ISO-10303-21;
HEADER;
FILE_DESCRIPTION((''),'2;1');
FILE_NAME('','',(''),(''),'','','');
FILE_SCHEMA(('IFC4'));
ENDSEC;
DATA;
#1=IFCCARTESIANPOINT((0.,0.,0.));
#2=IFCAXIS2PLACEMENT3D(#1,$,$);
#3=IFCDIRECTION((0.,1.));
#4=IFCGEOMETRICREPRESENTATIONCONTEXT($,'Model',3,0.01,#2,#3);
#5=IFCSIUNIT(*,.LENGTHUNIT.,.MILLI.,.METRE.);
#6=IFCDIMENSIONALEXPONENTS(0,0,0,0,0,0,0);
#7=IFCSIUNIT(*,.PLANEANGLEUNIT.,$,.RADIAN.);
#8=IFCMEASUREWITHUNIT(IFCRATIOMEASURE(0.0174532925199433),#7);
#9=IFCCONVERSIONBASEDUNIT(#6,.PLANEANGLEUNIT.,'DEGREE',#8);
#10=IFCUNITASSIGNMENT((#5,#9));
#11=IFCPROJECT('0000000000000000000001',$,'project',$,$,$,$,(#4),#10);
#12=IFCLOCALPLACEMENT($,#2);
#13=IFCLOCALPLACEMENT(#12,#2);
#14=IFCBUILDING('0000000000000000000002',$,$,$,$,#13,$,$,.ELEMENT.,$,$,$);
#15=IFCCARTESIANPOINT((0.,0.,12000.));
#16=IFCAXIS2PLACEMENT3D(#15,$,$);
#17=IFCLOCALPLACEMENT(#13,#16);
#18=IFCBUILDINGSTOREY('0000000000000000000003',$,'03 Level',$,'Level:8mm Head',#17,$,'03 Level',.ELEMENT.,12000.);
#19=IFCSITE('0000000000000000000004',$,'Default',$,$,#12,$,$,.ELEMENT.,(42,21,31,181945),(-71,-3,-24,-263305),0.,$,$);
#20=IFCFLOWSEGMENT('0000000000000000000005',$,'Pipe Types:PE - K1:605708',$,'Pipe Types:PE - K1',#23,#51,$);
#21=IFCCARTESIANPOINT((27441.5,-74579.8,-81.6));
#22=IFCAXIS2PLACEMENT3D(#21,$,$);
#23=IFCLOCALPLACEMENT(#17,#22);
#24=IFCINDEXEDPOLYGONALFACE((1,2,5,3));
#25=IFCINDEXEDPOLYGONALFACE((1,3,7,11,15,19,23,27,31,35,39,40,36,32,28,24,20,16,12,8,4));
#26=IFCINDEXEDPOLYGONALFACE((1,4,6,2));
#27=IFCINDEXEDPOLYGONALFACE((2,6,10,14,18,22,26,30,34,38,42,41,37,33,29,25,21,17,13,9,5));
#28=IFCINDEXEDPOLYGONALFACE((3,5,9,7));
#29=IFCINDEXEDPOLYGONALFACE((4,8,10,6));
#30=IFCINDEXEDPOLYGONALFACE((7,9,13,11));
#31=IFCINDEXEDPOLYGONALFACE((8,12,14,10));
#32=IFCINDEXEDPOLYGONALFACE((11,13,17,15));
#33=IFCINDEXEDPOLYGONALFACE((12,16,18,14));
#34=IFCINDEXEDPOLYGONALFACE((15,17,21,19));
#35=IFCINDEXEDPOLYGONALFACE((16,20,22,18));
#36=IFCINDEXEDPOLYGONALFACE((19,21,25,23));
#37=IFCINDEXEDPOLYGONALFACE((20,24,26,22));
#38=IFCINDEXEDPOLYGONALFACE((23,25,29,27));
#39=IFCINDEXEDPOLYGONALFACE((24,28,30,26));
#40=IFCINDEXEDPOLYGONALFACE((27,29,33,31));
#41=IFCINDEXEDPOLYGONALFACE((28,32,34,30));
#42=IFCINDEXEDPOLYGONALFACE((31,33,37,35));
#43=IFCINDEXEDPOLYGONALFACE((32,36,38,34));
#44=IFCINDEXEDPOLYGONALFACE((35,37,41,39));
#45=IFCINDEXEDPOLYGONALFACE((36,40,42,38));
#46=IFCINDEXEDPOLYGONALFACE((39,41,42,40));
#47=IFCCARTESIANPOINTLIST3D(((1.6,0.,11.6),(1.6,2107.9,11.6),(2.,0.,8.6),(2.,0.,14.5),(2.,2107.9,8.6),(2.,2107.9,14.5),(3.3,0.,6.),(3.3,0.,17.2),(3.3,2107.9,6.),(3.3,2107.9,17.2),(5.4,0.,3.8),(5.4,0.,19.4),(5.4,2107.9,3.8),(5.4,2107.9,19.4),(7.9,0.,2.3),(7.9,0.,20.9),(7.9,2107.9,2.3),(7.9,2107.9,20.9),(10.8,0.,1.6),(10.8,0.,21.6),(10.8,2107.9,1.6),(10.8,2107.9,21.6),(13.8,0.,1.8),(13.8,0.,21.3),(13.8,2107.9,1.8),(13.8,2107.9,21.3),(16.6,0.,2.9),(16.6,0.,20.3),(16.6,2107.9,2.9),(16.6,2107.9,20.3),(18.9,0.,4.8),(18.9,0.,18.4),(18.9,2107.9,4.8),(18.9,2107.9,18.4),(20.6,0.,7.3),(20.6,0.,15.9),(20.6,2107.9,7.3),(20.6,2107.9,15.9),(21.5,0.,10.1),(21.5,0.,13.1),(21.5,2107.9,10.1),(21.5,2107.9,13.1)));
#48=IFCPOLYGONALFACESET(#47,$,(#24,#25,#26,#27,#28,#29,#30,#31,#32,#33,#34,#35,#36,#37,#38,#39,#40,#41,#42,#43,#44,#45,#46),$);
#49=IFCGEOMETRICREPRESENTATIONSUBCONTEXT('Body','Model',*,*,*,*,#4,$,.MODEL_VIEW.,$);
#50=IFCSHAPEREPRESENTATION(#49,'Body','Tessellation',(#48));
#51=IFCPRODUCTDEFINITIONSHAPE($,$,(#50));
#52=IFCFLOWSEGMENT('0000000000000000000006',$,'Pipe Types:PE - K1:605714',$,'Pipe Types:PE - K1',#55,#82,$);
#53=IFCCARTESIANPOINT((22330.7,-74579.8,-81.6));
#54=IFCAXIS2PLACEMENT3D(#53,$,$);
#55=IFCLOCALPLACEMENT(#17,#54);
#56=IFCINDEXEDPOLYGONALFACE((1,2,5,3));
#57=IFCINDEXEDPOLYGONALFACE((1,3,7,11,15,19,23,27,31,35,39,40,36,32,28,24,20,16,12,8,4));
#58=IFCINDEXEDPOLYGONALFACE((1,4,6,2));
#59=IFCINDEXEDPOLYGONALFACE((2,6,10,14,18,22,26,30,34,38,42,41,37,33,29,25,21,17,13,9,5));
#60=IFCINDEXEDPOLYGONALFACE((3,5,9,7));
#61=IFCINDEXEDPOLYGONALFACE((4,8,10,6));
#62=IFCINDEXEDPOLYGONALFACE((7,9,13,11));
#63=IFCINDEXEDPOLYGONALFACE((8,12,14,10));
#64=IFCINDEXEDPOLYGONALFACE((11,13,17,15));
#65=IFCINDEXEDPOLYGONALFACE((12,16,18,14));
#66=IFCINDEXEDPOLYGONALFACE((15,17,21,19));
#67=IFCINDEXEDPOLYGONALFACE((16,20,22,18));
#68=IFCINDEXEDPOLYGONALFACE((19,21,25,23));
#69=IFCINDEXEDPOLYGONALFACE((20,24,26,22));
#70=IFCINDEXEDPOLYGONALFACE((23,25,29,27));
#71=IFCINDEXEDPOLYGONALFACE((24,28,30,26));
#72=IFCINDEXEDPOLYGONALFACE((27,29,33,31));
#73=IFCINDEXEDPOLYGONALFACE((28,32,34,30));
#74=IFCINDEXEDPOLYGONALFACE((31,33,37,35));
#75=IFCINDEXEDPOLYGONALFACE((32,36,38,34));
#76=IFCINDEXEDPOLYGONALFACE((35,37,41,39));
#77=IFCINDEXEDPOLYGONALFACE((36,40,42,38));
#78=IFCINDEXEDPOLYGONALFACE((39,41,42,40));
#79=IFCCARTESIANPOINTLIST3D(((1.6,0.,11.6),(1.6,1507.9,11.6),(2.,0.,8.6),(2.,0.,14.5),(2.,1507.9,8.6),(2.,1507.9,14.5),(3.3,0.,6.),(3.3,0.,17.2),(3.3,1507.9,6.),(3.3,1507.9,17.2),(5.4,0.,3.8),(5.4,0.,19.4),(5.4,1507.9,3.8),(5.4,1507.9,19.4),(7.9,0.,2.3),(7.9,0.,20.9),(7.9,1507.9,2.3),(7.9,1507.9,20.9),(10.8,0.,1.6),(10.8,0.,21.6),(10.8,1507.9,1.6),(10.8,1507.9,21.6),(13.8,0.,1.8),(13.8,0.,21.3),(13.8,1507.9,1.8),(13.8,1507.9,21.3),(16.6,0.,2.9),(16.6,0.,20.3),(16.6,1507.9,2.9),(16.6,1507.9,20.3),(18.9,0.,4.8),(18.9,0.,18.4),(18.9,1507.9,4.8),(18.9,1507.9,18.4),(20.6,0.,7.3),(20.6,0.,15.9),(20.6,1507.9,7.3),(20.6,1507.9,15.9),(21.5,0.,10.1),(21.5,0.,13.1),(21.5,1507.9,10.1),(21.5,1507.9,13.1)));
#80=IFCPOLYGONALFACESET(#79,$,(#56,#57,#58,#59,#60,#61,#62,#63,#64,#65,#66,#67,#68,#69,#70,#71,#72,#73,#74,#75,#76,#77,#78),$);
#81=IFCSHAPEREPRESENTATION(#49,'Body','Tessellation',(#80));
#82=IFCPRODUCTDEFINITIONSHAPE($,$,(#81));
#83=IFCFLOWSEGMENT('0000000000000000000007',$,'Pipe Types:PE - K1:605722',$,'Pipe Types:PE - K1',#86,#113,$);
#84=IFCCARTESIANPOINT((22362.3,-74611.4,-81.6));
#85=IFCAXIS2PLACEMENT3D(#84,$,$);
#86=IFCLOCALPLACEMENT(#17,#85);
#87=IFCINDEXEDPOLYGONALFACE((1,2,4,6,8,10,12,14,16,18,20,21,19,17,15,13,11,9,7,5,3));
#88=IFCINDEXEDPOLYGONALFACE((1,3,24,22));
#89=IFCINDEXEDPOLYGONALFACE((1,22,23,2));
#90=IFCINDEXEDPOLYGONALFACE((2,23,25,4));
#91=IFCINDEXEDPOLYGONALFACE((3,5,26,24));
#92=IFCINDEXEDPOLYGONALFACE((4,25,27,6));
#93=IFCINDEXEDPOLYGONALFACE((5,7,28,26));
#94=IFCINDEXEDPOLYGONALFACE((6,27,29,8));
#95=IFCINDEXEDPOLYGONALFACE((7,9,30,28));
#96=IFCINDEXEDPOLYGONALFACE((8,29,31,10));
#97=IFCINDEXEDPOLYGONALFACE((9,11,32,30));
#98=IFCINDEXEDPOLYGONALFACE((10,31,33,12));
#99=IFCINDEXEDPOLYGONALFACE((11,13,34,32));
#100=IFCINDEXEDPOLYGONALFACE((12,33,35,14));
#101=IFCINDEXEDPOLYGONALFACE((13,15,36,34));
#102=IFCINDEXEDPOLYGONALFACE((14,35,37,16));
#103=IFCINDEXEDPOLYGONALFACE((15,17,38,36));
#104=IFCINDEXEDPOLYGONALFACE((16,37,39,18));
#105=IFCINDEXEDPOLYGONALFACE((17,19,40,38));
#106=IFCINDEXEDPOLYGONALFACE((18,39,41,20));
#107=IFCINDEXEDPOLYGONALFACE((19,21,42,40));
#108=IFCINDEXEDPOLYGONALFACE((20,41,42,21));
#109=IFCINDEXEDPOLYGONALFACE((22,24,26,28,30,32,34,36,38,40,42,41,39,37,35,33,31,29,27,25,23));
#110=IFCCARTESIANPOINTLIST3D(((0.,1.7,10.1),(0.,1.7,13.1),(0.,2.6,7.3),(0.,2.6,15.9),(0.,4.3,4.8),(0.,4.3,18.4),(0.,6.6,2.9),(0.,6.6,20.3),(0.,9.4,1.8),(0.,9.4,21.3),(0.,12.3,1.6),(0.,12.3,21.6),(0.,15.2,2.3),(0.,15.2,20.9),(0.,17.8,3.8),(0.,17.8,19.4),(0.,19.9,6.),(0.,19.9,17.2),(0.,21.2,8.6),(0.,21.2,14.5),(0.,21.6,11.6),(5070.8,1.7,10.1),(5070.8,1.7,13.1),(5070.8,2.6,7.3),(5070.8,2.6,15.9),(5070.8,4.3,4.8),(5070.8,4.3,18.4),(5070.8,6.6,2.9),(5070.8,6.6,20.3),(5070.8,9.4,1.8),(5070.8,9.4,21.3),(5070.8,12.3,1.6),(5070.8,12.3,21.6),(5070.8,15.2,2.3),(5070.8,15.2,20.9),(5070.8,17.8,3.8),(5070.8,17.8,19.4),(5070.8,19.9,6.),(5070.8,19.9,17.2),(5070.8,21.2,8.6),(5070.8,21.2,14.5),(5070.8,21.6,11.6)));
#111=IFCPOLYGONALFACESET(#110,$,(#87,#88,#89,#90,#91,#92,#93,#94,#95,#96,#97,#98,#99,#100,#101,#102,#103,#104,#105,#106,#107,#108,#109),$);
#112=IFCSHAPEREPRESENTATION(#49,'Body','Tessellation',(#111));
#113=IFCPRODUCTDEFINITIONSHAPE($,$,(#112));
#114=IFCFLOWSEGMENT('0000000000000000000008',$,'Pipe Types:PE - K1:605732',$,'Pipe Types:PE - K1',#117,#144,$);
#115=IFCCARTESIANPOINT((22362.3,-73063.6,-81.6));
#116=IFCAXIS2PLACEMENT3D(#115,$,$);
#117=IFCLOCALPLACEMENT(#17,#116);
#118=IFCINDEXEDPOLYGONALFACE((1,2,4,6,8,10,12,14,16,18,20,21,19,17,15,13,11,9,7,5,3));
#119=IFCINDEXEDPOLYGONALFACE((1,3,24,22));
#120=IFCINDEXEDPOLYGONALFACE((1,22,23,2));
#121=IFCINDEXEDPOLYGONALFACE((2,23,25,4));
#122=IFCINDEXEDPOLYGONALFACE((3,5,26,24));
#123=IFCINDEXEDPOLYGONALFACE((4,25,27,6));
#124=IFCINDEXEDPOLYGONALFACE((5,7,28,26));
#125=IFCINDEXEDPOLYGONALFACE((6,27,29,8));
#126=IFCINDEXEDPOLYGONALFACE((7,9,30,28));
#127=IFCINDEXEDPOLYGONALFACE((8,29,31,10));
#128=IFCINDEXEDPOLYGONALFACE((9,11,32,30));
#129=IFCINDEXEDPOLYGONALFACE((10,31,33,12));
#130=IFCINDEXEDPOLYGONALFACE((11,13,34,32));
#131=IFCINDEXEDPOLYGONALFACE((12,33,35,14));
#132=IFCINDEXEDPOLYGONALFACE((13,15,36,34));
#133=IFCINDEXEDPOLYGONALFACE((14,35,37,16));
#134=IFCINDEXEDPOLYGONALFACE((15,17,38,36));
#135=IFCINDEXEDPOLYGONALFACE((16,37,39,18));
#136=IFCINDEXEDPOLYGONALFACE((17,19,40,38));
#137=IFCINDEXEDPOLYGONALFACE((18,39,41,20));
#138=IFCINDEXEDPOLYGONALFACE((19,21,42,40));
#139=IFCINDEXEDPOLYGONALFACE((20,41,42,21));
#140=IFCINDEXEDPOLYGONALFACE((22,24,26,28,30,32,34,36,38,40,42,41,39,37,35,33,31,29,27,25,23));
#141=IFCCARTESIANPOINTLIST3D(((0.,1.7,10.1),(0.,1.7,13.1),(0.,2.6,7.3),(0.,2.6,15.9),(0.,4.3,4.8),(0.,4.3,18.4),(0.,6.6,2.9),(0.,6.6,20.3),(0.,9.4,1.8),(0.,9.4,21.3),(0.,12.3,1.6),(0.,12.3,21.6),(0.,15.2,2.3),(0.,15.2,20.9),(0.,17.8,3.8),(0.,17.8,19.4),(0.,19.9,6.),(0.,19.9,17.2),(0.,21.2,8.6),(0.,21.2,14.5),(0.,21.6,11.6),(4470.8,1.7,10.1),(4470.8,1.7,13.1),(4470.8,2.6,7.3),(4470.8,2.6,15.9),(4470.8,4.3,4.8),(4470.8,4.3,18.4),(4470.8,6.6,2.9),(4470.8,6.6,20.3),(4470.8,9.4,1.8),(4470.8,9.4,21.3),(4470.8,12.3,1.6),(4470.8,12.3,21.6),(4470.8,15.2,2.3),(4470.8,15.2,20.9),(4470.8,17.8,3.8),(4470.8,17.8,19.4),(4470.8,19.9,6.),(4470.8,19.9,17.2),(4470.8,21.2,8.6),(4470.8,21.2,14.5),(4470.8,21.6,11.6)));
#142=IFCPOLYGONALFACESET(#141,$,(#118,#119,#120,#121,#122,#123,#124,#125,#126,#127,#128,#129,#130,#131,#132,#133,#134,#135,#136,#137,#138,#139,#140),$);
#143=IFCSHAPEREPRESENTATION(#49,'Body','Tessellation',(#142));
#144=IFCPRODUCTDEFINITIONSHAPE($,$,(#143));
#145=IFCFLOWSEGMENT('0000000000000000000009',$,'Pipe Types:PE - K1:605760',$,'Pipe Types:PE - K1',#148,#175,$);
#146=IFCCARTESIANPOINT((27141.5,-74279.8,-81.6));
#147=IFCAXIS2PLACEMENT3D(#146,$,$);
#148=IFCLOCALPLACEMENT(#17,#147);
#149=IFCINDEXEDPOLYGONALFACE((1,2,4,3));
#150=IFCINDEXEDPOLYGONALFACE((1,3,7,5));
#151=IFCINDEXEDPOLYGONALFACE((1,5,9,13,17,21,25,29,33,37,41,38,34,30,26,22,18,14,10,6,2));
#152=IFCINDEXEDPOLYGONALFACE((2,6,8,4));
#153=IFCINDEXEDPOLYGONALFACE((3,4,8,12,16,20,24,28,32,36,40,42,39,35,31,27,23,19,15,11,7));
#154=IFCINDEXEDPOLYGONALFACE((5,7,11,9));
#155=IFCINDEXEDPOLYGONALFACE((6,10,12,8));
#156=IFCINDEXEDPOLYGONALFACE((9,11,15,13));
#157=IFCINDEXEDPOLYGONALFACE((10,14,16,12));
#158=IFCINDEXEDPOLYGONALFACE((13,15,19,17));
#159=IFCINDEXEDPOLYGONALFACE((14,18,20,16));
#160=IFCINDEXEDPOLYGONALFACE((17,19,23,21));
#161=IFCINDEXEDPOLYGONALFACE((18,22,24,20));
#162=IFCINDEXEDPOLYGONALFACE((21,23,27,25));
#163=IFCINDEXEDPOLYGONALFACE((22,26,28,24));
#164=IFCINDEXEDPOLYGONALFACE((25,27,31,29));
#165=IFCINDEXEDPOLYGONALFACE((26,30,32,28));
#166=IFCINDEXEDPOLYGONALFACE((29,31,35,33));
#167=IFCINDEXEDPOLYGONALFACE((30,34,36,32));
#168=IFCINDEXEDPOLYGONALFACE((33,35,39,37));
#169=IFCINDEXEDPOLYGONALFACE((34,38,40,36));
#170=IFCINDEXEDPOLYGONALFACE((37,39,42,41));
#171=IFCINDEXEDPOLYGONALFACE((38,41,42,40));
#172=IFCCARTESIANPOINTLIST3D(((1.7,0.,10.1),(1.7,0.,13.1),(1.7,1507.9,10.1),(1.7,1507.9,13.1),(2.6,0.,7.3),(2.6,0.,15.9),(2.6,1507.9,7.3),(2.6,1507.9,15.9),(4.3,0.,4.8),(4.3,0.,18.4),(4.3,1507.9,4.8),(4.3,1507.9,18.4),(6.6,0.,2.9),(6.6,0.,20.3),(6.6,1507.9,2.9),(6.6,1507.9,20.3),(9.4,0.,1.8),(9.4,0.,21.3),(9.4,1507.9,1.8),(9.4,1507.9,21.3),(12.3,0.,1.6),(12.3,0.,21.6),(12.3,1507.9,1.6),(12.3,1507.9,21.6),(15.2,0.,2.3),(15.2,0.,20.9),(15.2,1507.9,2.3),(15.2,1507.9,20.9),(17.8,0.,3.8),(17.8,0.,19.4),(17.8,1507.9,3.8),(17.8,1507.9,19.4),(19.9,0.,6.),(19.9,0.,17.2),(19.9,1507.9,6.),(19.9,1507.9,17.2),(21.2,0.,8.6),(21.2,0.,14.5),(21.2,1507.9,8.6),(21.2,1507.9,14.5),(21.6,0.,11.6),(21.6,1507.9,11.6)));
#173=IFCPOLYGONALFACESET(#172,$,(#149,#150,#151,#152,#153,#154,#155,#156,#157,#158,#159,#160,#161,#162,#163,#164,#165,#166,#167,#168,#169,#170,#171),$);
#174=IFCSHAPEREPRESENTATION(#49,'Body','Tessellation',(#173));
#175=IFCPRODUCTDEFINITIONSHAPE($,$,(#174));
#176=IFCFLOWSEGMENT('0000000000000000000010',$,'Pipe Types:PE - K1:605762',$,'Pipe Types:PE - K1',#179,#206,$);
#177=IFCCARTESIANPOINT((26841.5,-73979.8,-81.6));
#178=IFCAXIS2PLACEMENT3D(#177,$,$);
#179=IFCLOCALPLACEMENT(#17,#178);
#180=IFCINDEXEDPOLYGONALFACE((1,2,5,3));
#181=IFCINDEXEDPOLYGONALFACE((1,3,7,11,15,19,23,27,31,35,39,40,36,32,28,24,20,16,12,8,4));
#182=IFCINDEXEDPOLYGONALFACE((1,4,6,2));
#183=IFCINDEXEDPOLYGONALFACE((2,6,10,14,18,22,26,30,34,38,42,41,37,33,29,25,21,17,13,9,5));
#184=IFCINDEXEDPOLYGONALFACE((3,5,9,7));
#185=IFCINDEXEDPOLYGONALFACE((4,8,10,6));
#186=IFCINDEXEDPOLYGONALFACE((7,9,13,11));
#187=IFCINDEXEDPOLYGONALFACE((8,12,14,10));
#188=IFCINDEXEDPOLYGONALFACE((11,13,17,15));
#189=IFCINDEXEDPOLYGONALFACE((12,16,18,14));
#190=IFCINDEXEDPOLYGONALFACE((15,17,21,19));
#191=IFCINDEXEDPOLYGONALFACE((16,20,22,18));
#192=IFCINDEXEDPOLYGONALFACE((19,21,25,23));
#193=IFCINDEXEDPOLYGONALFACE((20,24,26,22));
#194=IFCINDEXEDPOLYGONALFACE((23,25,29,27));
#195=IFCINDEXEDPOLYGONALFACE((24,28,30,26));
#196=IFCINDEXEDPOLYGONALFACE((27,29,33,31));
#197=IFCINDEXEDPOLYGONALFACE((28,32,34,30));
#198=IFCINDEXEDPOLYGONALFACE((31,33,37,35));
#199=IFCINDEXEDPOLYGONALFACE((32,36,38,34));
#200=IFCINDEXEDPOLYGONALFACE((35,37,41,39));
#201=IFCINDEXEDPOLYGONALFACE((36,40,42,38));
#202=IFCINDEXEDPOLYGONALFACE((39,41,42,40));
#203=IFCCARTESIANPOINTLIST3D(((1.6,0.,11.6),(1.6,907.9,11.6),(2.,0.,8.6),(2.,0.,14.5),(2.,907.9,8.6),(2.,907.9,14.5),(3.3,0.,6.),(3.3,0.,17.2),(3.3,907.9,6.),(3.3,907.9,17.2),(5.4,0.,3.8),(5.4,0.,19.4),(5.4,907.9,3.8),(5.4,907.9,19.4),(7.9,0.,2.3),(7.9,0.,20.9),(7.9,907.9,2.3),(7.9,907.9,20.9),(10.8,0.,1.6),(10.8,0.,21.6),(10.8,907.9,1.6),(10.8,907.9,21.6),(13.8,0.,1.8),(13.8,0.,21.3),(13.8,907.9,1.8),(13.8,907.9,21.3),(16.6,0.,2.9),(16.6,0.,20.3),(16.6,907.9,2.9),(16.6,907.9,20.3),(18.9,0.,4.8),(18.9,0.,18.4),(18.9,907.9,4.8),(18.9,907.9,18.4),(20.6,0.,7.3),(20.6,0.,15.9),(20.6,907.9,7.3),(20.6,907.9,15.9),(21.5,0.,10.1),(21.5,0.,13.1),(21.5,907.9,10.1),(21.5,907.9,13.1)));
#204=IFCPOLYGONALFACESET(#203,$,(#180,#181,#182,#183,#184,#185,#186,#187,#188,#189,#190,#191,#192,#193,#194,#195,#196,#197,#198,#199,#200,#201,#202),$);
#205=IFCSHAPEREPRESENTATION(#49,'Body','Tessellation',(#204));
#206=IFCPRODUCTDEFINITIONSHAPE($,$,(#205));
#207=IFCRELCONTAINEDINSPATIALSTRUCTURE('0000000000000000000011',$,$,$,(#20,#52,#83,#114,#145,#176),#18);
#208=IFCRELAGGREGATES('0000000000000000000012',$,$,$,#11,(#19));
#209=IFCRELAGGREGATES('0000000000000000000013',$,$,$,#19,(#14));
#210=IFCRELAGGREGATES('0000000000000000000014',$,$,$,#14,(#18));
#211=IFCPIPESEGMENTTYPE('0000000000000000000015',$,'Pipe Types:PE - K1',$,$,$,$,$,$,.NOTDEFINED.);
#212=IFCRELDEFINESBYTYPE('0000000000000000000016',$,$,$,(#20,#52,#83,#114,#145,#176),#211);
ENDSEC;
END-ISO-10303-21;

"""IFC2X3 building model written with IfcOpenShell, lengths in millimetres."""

from ifc_helpers import new_model, entity, si_unit, converted_unit, direction, frame, frame_2d, origin, place, context, subcontext, project, spatial, circle, extrude, type_object, element, save


model = new_model("IFC2X3")

# Units and contexts
model_context = context("Model", 3, precision=0.01, world=origin(), true_north=direction((0.0, 1.0)))
body_context = subcontext(model_context, "Body", "Model", "MODEL_VIEW")
ifc_project = project(units=[si_unit("LENGTHUNIT", "METRE", prefix="MILLI"), converted_unit("PLANEANGLEUNIT", "DEGREE", entity("IfcRatioMeasure", 0.0174532925199433), si_unit("PLANEANGLEUNIT", "RADIAN"), dimensions=[0, 0, 0, 0, 0, 0, 0])], contexts=[model_context])

# Site, building, storey
site_placement = place(None, origin())
site = spatial("IfcSite", under=ifc_project, at=site_placement, Name="Default", CompositionType="ELEMENT", RefLatitude=(42, 21, 31, 181945), RefLongitude=(-71, -3, -24, -263305), RefElevation=0.0)
building_placement = place(site_placement, origin())
building = spatial("IfcBuilding", under=site, at=building_placement, CompositionType="ELEMENT")
storey_placement = place(building_placement, frame((0.0, 0.0, 12000.0)))
storey = spatial("IfcBuildingStorey", under=building, at=storey_placement, Name="03 Level", ObjectType="Level:8mm Head", LongName="03 Level", CompositionType="ELEMENT", Elevation=12000.0)

# Flow segments
pipe_segment_type = type_object("IfcPipeSegmentType", Name="Pipe Types:PE - K1", PredefinedType="NOTDEFINED")
flow_segment_1_placement = place(storey_placement, frame((27441.5, -74579.8, -81.6)))
element("IfcFlowSegment", 1, at=flow_segment_1_placement, inside=storey, type_object=pipe_segment_type, Name="Pipe Types:PE - K1:605708", ObjectType="Pipe Types:PE - K1", context=body_context, shape_type="SweptSolid", body=[
    extrude(circle(Radius=10.0, at=frame_2d((0.0, 0.0), x_axis=(1.0, 0.0))), frame((11.6, 0.0, 11.6), z_axis=(0.0, 1.0, 0.0), x_axis=(-1.0, 0.0, 0.0)), (0.0, 0.0, 1.0), 2107.9),
])
flow_segment_2_placement = place(storey_placement, frame((22330.7, -74579.8, -81.6)))
element("IfcFlowSegment", 2, at=flow_segment_2_placement, inside=storey, type_object=pipe_segment_type, Name="Pipe Types:PE - K1:605714", ObjectType="Pipe Types:PE - K1", context=body_context, shape_type="SweptSolid", body=[
    extrude(circle(Radius=10.0, at=frame_2d((0.0, 0.0), x_axis=(1.0, 0.0))), frame((11.6, 0.0, 11.6), z_axis=(0.0, 1.0, 0.0), x_axis=(-1.0, 0.0, 0.0)), (0.0, 0.0, 1.0), 1507.9),
])
flow_segment_3_placement = place(storey_placement, frame((22362.3, -74611.4, -81.6)))
element("IfcFlowSegment", 3, at=flow_segment_3_placement, inside=storey, type_object=pipe_segment_type, Name="Pipe Types:PE - K1:605722", ObjectType="Pipe Types:PE - K1", context=body_context, shape_type="SweptSolid", body=[
    extrude(circle(Radius=10.0, at=frame_2d((0.0, 0.0), x_axis=(1.0, 0.0))), frame((0.0, 11.6, 11.6), z_axis=(1.0, 0.0, 0.0), x_axis=(0.0, 1.0, 0.0)), (0.0, 0.0, 1.0), 5070.8),
])
flow_segment_4_placement = place(storey_placement, frame((22362.3, -73063.6, -81.6)))
element("IfcFlowSegment", 4, at=flow_segment_4_placement, inside=storey, type_object=pipe_segment_type, Name="Pipe Types:PE - K1:605732", ObjectType="Pipe Types:PE - K1", context=body_context, shape_type="SweptSolid", body=[
    extrude(circle(Radius=10.0, at=frame_2d((0.0, 0.0), x_axis=(1.0, 0.0))), frame((0.0, 11.6, 11.6), z_axis=(1.0, 0.0, 0.0), x_axis=(0.0, 1.0, 0.0)), (0.0, 0.0, 1.0), 4470.8),
])
flow_segment_5_placement = place(storey_placement, frame((27141.5, -74279.8, -81.6)))
element("IfcFlowSegment", 5, at=flow_segment_5_placement, inside=storey, type_object=pipe_segment_type, Name="Pipe Types:PE - K1:605760", ObjectType="Pipe Types:PE - K1", context=body_context, shape_type="SweptSolid", body=[
    extrude(circle(Radius=10.0, at=frame_2d((0.0, 0.0), x_axis=(1.0, 0.0))), frame((11.6, 0.0, 11.6), z_axis=(0.0, 1.0, 0.0), x_axis=(1.0, 0.0, 0.0)), (0.0, 0.0, 1.0), 1507.9),
])
flow_segment_6_placement = place(storey_placement, frame((26841.5, -73979.8, -81.6)))
element("IfcFlowSegment", 6, at=flow_segment_6_placement, inside=storey, type_object=pipe_segment_type, Name="Pipe Types:PE - K1:605762", ObjectType="Pipe Types:PE - K1", context=body_context, shape_type="SweptSolid", body=[
    extrude(circle(Radius=10.0, at=frame_2d((0.0, 0.0), x_axis=(1.0, 0.0))), frame((11.6, 0.0, 11.6), z_axis=(0.0, 1.0, 0.0), x_axis=(-1.0, 0.0, 0.0)), (0.0, 0.0, 1.0), 907.9),
])

save(model, "model.ifc")
